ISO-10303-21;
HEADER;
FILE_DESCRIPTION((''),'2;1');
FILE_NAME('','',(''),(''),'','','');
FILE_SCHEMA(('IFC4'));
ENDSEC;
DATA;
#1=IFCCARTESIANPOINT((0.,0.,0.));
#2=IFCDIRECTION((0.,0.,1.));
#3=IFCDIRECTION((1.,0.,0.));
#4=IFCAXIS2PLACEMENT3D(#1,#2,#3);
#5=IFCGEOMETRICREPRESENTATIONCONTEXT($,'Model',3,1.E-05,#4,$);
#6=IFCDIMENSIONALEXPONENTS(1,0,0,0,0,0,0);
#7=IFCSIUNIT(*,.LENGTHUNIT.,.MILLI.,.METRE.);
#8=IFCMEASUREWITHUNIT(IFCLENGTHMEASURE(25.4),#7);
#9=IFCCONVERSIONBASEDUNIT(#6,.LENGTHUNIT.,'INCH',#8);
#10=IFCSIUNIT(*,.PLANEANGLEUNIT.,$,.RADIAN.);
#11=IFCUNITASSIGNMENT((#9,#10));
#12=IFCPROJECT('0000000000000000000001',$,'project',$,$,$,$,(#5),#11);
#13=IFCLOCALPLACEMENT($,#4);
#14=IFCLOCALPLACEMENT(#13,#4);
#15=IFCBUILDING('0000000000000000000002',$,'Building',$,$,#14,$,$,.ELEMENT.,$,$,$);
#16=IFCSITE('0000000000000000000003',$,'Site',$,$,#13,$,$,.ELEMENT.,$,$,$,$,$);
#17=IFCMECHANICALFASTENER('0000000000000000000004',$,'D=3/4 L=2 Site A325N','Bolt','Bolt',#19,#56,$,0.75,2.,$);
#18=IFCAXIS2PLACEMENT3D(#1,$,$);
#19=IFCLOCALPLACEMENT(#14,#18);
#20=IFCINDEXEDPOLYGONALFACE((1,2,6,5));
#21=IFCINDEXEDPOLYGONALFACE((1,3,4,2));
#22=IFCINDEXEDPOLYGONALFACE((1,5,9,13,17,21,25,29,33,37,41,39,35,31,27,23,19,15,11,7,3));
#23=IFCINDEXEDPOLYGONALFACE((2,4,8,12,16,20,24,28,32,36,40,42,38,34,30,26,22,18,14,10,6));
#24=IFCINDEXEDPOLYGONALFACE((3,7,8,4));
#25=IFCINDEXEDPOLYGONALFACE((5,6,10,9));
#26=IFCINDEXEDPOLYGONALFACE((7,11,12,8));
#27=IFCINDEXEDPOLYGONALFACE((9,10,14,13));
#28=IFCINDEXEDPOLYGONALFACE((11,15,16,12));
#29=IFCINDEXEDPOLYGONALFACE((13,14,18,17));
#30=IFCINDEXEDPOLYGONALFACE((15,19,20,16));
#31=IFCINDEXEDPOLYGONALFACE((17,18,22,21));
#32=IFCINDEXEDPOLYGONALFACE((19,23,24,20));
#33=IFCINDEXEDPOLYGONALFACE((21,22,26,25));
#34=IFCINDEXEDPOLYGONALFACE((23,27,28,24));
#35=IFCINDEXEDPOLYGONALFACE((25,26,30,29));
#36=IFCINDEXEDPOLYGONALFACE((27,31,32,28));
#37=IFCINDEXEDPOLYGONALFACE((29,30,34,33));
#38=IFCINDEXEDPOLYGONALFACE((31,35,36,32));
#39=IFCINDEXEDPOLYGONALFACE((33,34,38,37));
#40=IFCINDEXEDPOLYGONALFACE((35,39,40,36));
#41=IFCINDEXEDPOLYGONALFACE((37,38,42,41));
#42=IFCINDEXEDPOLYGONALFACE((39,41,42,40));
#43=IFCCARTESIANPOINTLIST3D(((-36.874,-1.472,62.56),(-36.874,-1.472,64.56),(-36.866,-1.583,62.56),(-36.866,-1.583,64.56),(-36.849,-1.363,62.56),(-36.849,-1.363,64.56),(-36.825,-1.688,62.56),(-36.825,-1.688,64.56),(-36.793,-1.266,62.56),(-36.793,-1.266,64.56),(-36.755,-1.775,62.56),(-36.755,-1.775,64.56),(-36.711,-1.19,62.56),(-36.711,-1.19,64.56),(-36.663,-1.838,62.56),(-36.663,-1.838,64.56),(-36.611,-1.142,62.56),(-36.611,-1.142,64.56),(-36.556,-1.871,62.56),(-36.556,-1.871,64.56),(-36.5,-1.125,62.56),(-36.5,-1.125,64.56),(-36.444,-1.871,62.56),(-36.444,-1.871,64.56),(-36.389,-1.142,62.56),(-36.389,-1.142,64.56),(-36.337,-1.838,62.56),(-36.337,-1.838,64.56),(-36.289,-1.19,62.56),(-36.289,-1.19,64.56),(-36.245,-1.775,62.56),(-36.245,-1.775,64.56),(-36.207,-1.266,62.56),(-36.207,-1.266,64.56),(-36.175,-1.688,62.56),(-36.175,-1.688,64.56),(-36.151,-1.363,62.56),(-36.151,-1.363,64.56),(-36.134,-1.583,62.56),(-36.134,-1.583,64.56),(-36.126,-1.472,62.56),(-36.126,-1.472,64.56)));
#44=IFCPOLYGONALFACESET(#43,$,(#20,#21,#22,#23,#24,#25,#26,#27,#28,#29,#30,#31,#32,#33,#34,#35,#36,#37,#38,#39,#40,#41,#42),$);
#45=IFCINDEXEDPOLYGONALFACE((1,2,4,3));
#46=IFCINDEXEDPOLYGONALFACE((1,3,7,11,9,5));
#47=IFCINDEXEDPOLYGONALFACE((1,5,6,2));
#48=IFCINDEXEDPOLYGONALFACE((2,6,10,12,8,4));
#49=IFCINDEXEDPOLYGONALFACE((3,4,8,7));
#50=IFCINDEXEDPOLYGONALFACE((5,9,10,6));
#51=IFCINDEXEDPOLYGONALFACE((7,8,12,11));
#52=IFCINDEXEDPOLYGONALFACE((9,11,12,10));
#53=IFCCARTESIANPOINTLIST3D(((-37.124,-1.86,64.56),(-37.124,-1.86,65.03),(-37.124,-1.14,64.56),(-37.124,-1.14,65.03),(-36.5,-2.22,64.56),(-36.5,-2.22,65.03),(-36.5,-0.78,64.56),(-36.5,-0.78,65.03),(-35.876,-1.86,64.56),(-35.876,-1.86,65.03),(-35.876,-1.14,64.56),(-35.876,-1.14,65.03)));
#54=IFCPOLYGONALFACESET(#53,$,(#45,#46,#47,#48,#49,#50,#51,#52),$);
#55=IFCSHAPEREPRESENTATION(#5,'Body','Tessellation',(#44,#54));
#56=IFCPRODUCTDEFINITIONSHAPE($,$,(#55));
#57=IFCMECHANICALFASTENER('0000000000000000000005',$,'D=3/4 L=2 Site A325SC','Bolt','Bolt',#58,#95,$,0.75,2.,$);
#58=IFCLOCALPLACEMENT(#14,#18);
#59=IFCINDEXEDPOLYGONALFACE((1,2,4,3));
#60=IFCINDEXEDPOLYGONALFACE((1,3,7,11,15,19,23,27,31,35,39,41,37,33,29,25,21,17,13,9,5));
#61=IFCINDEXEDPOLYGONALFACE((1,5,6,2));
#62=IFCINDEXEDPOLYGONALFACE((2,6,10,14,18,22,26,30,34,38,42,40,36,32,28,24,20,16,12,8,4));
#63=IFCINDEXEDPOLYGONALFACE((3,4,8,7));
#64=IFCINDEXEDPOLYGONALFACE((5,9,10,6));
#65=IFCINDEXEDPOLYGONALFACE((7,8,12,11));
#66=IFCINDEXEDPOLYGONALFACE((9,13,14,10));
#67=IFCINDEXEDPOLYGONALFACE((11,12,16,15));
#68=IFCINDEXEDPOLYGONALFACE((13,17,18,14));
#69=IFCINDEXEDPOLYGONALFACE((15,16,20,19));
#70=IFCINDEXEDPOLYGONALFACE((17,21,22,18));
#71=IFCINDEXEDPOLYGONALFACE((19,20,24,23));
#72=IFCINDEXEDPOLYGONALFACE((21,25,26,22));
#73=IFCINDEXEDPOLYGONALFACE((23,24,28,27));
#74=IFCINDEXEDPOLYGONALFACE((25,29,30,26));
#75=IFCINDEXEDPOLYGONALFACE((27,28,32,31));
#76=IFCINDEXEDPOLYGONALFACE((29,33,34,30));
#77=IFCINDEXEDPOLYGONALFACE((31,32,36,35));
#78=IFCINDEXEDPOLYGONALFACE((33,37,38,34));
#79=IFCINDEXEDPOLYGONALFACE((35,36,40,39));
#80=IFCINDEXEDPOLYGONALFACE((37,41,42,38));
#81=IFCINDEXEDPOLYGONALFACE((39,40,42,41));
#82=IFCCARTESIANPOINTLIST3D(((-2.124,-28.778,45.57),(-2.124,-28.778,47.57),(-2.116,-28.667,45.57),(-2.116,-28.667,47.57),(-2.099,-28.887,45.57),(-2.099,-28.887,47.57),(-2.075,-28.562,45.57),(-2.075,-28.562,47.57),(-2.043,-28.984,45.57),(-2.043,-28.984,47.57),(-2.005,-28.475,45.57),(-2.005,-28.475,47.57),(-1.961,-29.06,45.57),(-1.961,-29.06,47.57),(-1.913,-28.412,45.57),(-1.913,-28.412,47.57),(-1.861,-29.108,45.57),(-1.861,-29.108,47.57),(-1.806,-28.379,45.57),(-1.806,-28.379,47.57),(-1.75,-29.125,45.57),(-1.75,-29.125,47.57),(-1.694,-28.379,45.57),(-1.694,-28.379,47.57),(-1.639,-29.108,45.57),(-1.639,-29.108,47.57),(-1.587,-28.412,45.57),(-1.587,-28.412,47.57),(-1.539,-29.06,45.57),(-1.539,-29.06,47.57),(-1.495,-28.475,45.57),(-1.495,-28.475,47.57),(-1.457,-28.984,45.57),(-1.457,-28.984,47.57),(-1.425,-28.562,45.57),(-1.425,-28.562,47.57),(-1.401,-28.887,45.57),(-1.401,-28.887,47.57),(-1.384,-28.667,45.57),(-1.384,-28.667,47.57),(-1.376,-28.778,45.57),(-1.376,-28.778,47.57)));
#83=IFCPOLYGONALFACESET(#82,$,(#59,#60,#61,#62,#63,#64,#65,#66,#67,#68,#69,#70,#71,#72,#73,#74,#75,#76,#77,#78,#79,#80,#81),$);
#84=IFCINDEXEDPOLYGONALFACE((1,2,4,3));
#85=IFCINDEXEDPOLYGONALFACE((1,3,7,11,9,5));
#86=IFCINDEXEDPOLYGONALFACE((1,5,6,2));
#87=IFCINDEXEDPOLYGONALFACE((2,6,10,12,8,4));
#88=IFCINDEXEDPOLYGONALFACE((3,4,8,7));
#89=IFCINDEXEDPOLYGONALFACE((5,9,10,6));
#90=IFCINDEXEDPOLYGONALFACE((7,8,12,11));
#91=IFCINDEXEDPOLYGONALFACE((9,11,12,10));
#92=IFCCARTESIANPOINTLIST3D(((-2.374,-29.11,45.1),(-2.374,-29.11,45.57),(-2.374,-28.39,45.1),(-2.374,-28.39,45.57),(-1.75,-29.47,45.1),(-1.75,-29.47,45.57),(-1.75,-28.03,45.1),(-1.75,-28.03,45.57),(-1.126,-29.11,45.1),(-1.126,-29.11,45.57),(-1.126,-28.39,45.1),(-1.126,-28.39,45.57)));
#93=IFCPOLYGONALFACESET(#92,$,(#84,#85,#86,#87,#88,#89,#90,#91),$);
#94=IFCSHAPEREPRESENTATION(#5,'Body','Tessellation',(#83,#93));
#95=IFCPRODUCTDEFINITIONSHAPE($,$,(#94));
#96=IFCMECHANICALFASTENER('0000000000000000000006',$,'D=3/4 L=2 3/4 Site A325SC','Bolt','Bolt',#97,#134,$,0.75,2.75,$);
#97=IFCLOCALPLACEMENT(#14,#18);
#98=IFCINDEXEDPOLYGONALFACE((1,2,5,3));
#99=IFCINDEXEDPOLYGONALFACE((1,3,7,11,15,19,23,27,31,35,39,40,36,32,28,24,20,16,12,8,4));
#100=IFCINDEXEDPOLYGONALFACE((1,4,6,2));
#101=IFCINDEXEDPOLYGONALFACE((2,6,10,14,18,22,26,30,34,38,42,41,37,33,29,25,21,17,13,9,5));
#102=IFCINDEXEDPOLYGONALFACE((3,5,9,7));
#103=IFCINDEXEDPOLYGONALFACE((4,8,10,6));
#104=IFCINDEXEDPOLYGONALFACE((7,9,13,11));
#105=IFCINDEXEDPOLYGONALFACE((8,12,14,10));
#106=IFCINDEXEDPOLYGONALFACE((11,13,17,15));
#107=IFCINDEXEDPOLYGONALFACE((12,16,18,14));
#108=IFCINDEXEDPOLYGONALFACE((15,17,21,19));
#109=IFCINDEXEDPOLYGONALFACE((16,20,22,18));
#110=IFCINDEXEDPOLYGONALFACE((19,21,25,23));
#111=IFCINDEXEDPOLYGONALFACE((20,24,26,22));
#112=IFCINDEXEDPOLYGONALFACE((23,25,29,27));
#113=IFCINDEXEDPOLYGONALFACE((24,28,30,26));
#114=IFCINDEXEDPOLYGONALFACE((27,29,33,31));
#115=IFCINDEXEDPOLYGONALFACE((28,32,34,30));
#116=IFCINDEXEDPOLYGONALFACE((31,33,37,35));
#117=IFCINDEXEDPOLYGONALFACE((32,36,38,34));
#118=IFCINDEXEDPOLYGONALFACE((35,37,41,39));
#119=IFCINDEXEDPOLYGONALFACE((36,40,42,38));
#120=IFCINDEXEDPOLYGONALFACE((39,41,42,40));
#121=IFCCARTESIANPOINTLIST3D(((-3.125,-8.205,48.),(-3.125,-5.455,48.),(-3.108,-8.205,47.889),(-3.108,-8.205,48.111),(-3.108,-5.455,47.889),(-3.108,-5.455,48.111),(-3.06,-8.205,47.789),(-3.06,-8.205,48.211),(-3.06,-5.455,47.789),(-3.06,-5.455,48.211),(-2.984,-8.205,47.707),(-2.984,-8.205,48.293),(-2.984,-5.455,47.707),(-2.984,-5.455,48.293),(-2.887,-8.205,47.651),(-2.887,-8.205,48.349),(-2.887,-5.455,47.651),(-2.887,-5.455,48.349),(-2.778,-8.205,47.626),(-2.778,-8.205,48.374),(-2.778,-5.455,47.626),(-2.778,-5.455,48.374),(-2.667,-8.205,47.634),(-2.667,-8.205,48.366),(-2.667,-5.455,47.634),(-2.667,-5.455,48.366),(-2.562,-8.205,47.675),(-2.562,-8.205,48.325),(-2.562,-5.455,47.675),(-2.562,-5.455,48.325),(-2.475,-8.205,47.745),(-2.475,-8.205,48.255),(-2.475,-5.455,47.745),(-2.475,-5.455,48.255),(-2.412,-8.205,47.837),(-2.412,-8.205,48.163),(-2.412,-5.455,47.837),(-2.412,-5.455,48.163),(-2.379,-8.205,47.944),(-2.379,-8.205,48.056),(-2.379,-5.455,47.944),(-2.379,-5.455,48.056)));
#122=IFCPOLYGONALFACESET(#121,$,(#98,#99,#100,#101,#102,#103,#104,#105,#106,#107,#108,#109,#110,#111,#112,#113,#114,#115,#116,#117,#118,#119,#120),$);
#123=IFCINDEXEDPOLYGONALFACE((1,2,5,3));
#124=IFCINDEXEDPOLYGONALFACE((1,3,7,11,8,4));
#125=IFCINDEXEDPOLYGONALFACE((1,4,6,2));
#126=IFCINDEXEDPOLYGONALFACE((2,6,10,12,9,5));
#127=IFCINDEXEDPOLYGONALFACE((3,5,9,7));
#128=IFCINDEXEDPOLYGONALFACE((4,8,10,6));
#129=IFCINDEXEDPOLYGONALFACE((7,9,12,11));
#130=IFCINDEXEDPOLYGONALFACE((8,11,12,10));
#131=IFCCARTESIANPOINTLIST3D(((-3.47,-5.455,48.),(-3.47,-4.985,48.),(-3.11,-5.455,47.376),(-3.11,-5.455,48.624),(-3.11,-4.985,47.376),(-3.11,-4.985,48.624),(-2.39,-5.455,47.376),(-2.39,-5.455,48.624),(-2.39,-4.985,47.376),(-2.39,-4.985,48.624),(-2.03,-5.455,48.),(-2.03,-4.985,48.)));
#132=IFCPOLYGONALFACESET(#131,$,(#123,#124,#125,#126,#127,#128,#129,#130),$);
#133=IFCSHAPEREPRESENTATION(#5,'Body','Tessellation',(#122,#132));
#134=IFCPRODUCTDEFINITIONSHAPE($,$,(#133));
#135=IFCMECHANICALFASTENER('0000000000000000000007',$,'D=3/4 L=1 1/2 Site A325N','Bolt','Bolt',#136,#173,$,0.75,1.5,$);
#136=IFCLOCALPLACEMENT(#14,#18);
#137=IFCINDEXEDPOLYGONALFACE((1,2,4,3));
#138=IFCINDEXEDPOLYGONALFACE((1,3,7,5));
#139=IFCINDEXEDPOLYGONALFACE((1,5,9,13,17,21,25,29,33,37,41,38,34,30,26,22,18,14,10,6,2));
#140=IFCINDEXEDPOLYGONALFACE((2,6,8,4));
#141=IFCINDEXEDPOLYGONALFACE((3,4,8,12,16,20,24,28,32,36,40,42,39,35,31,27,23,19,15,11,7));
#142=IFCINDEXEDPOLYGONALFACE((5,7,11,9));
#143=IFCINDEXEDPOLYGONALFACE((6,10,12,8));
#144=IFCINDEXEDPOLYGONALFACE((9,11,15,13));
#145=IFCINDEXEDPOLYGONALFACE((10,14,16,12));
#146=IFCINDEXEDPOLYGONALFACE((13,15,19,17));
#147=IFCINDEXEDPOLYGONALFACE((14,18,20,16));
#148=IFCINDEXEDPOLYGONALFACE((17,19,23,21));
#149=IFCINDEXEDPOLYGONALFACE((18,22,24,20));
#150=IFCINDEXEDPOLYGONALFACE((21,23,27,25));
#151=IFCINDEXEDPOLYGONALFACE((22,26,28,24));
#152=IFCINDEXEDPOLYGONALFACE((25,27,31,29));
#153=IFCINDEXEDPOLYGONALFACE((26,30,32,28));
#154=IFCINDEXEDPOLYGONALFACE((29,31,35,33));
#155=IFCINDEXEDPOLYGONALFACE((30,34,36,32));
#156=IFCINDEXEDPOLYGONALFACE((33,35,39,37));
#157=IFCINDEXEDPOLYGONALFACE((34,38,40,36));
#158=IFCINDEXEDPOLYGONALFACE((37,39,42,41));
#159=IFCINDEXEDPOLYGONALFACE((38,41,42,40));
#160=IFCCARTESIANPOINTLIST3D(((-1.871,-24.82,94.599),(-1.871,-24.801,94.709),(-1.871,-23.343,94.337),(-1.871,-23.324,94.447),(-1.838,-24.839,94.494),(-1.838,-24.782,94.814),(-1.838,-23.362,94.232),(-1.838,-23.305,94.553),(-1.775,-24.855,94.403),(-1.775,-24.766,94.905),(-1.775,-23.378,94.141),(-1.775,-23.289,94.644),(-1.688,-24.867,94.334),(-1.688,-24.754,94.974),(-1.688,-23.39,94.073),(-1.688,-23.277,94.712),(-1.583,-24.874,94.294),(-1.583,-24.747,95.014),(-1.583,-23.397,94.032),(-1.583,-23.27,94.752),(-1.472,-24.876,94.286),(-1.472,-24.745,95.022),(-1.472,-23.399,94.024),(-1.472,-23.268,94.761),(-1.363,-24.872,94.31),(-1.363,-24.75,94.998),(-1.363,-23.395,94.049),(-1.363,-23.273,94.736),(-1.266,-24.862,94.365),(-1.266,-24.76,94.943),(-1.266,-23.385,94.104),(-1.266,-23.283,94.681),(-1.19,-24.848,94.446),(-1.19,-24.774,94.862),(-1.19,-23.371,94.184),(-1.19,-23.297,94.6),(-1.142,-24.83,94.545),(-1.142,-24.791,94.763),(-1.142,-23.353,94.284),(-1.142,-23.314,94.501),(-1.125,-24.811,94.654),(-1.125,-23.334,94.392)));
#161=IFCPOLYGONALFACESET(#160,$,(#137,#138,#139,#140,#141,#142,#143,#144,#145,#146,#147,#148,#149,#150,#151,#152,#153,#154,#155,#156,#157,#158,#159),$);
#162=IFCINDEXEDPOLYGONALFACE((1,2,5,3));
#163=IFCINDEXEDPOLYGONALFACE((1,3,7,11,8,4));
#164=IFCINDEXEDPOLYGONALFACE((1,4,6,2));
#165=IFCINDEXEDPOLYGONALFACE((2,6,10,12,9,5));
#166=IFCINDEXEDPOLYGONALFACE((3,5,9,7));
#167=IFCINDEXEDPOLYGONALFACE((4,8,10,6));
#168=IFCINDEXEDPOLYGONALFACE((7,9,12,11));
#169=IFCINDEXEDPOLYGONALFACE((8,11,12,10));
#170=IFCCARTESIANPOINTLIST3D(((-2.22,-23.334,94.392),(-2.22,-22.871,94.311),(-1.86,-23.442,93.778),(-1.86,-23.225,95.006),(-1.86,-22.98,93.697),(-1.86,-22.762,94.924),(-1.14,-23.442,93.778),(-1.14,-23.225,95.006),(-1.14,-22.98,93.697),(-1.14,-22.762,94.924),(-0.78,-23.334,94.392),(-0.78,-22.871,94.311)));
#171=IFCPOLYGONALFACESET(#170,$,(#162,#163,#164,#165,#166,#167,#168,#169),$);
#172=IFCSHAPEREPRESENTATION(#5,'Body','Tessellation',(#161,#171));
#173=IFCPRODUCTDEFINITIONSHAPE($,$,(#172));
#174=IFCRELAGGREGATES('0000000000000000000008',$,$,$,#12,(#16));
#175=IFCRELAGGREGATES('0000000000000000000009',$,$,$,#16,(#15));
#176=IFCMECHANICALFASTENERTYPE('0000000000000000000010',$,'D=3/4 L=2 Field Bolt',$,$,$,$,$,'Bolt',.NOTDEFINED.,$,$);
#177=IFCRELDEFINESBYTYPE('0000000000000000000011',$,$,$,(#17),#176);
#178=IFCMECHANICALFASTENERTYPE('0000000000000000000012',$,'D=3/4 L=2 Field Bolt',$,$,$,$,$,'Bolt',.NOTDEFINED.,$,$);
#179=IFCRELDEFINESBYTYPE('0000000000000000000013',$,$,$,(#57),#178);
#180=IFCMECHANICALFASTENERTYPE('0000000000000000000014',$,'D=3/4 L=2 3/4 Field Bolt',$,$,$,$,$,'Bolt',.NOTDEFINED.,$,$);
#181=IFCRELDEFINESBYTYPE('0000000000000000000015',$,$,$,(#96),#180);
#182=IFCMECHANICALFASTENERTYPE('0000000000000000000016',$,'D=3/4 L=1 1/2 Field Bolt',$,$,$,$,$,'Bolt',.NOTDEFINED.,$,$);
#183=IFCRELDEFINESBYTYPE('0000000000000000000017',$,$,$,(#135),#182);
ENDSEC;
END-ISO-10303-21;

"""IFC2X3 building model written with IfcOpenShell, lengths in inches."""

from ifc_helpers import new_model, entity, si_unit, converted_unit, frame, origin_with_axes, origin_2d_with_axis, place, context, project, spatial, polyline, circle, outline, extrude, source, transform, mapped, type_object, type_shapes, element, save


model = new_model("IFC2X3")

# Units and contexts
model_context = context("Model", 3, precision=1e-05, world=origin_with_axes())
ifc_project = project(units=[converted_unit("LENGTHUNIT", "INCH", entity("IfcLengthMeasure", 25.4), si_unit("LENGTHUNIT", "METRE", prefix="MILLI"), dimensions=[1, 0, 0, 0, 0, 0, 0]), si_unit("PLANEANGLEUNIT", "RADIAN")], contexts=[model_context])

# Site, building
site_placement = place(None, origin_with_axes())
site = spatial("IfcSite", under=ifc_project, at=site_placement, Name="Site", CompositionType="ELEMENT")
building_placement = place(site_placement, origin_with_axes())
building = spatial("IfcBuilding", under=site, at=building_placement, Name="Building", CompositionType="ELEMENT")

# Mechanical fasteners
mechanical_fastener_type_1 = type_object("IfcMechanicalFastenerType", Name="D=3/4 L=2 Field Bolt", ElementType="Bolt")
shared_shape_1 = source(origin_with_axes(), model_context, "Body", "SweptSolid", [
    extrude(circle(Radius=0.375, at=origin_2d_with_axis()), frame((0.0, 0.0, 0.0), z_axis=(1.0, 0.0, 0.0), x_axis=(0.0, 1.0, 0.0)), (0.0, 0.0, 1.0), 2.0),
    extrude(outline(polyline([(-0.72, 0.0), (-0.36, 0.624), (0.36, 0.624), (0.72, 0.0), (0.36, -0.624), (-0.36, -0.624), (-0.72, 0.0)])), frame((0.0, 0.0, 0.0), z_axis=(1.0, 0.0, 0.0), x_axis=(0.0, 1.0, 0.0)), (0.0, 0.0, -1.0), 0.47),
])
type_shapes(mechanical_fastener_type_1, [shared_shape_1])
placement_1 = place(building_placement, frame((-33.0, 0.0, 46.0), z_axis=(-1.0, 0.0, 0.0), x_axis=(0.0, 0.0, 1.0)))
placement_2 = place(placement_1, frame((18.56, -1.5, 3.5), z_axis=(0.0, 0.0, -1.0), x_axis=(-1.0, 0.0, 0.0)))
for number, where, z_axis, x_axis, name in (
    (1, (0.0, 0.0, 0.0), (0.0, 0.0, 1.0), (1.0, 0.0, 0.0), "D=3/4 L=2 Site A325N"),
):
    element("IfcMechanicalFastener", number, at=place(placement_2, frame(where, z_axis=z_axis, x_axis=x_axis)), type_object=mechanical_fastener_type_1, Name=name, Description="Bolt", ObjectType="Bolt", NominalDiameter=0.75, NominalLength=2.0, context=model_context, shape_type="MappedRepresentation", body=[
        mapped(shared_shape_1, transform((0.0, 0.0, 0.0), scale=1.0)),
    ])
placement_3 = place(building_placement, frame((0.0, -48.0, 94.0), z_axis=(0.0, 0.17437, 0.98468), x_axis=(0.0, 0.98468, -0.17437)))
mechanical_fastener_type_2 = type_object("IfcMechanicalFastenerType", Name="D=3/4 L=2 Field Bolt", ElementType="Bolt")
shared_shape_2 = source(origin_with_axes(), model_context, "Body", "SweptSolid", [
    extrude(circle(Radius=0.375, at=origin_2d_with_axis()), frame((0.0, 0.0, 0.0), z_axis=(1.0, 0.0, 0.0), x_axis=(0.0, 1.0, 0.0)), (0.0, 0.0, 1.0), 2.0),
    extrude(outline(polyline([(-0.72, 0.0), (-0.36, 0.624), (0.36, 0.624), (0.72, 0.0), (0.36, -0.624), (-0.36, -0.624), (-0.72, 0.0)])), frame((0.0, 0.0, 0.0), z_axis=(1.0, 0.0, 0.0), x_axis=(0.0, 1.0, 0.0)), (0.0, 0.0, -1.0), 0.47),
])
type_shapes(mechanical_fastener_type_2, [shared_shape_2])
placement_4 = place(building_placement, frame((0.0, 0.0, 46.0), z_axis=(0.0, 0.0, 1.0), x_axis=(0.0, -1.0, 0.0)))
placement_5 = place(placement_4, frame((28.75, -1.75, -0.43), z_axis=(0.0, 1.0, 0.0), x_axis=(0.0, 0.0, 1.0)))
mechanical_fastener_1_placement = place(placement_5, origin_with_axes())
element("IfcMechanicalFastener", 2, at=mechanical_fastener_1_placement, type_object=mechanical_fastener_type_2, Name="D=3/4 L=2 Site A325SC", Description="Bolt", ObjectType="Bolt", NominalDiameter=0.75, NominalLength=2.0, context=model_context, shape_type="MappedRepresentation", body=[
    mapped(shared_shape_2, transform((0.0, 0.0, 0.0), scale=1.0)),
])
mechanical_fastener_type_3 = type_object("IfcMechanicalFastenerType", Name="D=3/4 L=2 3/4 Field Bolt", ElementType="Bolt")
shared_shape_3 = source(origin_with_axes(), model_context, "Body", "SweptSolid", [
    extrude(circle(Radius=0.375, at=origin_2d_with_axis()), frame((0.0, 0.0, 0.0), z_axis=(1.0, 0.0, 0.0), x_axis=(0.0, 1.0, 0.0)), (0.0, 0.0, 1.0), 2.75),
    extrude(outline(polyline([(-0.72, 0.0), (-0.36, 0.624), (0.36, 0.624), (0.72, 0.0), (0.36, -0.624), (-0.36, -0.624), (-0.72, 0.0)])), frame((0.0, 0.0, 0.0), z_axis=(1.0, 0.0, 0.0), x_axis=(0.0, 1.0, 0.0)), (0.0, 0.0, -1.0), 0.47),
])
type_shapes(mechanical_fastener_type_3, [shared_shape_3])
placement_6 = place(placement_4, frame((5.455, -2.75, 2.0), z_axis=(0.0, 0.0, -1.0), x_axis=(1.0, 0.0, 0.0)))
mechanical_fastener_2_placement = place(placement_6, origin_with_axes())
element("IfcMechanicalFastener", 3, at=mechanical_fastener_2_placement, type_object=mechanical_fastener_type_3, Name="D=3/4 L=2 3/4 Site A325SC", Description="Bolt", ObjectType="Bolt", NominalDiameter=0.75, NominalLength=2.75, context=model_context, shape_type="MappedRepresentation", body=[
    mapped(shared_shape_3, transform((0.0, 0.0, 0.0), scale=1.0)),
])
mechanical_fastener_type_4 = type_object("IfcMechanicalFastenerType", Name="D=3/4 L=1 1/2 Field Bolt", ElementType="Bolt")
shared_shape_4 = source(origin_with_axes(), model_context, "Body", "SweptSolid", [
    extrude(circle(Radius=0.375, at=origin_2d_with_axis()), frame((0.0, 0.0, 0.0), z_axis=(1.0, 0.0, 0.0), x_axis=(0.0, 1.0, 0.0)), (0.0, 0.0, 1.0), 1.5),
    extrude(outline(polyline([(-0.72, 0.0), (-0.36, 0.624), (0.36, 0.624), (0.72, 0.0), (0.36, -0.624), (-0.36, -0.624), (-0.72, 0.0)])), frame((0.0, 0.0, 0.0), z_axis=(1.0, 0.0, 0.0), x_axis=(0.0, 1.0, 0.0)), (0.0, 0.0, -1.0), 0.47),
])
type_shapes(mechanical_fastener_type_4, [shared_shape_4])
placement_7 = place(placement_3, frame((24.22, 1.5, 4.688), z_axis=(0.0, 0.0, 1.0), x_axis=(-1.0, 0.0, 0.0)))
mechanical_fastener_3_placement = place(placement_7, origin_with_axes())
element("IfcMechanicalFastener", 4, at=mechanical_fastener_3_placement, type_object=mechanical_fastener_type_4, Name="D=3/4 L=1 1/2 Site A325N", Description="Bolt", ObjectType="Bolt", NominalDiameter=0.75, NominalLength=1.5, context=model_context, shape_type="MappedRepresentation", body=[
    mapped(shared_shape_4, transform((0.0, 0.0, 0.0), scale=1.0)),
])

save(model, "model.ifc")
